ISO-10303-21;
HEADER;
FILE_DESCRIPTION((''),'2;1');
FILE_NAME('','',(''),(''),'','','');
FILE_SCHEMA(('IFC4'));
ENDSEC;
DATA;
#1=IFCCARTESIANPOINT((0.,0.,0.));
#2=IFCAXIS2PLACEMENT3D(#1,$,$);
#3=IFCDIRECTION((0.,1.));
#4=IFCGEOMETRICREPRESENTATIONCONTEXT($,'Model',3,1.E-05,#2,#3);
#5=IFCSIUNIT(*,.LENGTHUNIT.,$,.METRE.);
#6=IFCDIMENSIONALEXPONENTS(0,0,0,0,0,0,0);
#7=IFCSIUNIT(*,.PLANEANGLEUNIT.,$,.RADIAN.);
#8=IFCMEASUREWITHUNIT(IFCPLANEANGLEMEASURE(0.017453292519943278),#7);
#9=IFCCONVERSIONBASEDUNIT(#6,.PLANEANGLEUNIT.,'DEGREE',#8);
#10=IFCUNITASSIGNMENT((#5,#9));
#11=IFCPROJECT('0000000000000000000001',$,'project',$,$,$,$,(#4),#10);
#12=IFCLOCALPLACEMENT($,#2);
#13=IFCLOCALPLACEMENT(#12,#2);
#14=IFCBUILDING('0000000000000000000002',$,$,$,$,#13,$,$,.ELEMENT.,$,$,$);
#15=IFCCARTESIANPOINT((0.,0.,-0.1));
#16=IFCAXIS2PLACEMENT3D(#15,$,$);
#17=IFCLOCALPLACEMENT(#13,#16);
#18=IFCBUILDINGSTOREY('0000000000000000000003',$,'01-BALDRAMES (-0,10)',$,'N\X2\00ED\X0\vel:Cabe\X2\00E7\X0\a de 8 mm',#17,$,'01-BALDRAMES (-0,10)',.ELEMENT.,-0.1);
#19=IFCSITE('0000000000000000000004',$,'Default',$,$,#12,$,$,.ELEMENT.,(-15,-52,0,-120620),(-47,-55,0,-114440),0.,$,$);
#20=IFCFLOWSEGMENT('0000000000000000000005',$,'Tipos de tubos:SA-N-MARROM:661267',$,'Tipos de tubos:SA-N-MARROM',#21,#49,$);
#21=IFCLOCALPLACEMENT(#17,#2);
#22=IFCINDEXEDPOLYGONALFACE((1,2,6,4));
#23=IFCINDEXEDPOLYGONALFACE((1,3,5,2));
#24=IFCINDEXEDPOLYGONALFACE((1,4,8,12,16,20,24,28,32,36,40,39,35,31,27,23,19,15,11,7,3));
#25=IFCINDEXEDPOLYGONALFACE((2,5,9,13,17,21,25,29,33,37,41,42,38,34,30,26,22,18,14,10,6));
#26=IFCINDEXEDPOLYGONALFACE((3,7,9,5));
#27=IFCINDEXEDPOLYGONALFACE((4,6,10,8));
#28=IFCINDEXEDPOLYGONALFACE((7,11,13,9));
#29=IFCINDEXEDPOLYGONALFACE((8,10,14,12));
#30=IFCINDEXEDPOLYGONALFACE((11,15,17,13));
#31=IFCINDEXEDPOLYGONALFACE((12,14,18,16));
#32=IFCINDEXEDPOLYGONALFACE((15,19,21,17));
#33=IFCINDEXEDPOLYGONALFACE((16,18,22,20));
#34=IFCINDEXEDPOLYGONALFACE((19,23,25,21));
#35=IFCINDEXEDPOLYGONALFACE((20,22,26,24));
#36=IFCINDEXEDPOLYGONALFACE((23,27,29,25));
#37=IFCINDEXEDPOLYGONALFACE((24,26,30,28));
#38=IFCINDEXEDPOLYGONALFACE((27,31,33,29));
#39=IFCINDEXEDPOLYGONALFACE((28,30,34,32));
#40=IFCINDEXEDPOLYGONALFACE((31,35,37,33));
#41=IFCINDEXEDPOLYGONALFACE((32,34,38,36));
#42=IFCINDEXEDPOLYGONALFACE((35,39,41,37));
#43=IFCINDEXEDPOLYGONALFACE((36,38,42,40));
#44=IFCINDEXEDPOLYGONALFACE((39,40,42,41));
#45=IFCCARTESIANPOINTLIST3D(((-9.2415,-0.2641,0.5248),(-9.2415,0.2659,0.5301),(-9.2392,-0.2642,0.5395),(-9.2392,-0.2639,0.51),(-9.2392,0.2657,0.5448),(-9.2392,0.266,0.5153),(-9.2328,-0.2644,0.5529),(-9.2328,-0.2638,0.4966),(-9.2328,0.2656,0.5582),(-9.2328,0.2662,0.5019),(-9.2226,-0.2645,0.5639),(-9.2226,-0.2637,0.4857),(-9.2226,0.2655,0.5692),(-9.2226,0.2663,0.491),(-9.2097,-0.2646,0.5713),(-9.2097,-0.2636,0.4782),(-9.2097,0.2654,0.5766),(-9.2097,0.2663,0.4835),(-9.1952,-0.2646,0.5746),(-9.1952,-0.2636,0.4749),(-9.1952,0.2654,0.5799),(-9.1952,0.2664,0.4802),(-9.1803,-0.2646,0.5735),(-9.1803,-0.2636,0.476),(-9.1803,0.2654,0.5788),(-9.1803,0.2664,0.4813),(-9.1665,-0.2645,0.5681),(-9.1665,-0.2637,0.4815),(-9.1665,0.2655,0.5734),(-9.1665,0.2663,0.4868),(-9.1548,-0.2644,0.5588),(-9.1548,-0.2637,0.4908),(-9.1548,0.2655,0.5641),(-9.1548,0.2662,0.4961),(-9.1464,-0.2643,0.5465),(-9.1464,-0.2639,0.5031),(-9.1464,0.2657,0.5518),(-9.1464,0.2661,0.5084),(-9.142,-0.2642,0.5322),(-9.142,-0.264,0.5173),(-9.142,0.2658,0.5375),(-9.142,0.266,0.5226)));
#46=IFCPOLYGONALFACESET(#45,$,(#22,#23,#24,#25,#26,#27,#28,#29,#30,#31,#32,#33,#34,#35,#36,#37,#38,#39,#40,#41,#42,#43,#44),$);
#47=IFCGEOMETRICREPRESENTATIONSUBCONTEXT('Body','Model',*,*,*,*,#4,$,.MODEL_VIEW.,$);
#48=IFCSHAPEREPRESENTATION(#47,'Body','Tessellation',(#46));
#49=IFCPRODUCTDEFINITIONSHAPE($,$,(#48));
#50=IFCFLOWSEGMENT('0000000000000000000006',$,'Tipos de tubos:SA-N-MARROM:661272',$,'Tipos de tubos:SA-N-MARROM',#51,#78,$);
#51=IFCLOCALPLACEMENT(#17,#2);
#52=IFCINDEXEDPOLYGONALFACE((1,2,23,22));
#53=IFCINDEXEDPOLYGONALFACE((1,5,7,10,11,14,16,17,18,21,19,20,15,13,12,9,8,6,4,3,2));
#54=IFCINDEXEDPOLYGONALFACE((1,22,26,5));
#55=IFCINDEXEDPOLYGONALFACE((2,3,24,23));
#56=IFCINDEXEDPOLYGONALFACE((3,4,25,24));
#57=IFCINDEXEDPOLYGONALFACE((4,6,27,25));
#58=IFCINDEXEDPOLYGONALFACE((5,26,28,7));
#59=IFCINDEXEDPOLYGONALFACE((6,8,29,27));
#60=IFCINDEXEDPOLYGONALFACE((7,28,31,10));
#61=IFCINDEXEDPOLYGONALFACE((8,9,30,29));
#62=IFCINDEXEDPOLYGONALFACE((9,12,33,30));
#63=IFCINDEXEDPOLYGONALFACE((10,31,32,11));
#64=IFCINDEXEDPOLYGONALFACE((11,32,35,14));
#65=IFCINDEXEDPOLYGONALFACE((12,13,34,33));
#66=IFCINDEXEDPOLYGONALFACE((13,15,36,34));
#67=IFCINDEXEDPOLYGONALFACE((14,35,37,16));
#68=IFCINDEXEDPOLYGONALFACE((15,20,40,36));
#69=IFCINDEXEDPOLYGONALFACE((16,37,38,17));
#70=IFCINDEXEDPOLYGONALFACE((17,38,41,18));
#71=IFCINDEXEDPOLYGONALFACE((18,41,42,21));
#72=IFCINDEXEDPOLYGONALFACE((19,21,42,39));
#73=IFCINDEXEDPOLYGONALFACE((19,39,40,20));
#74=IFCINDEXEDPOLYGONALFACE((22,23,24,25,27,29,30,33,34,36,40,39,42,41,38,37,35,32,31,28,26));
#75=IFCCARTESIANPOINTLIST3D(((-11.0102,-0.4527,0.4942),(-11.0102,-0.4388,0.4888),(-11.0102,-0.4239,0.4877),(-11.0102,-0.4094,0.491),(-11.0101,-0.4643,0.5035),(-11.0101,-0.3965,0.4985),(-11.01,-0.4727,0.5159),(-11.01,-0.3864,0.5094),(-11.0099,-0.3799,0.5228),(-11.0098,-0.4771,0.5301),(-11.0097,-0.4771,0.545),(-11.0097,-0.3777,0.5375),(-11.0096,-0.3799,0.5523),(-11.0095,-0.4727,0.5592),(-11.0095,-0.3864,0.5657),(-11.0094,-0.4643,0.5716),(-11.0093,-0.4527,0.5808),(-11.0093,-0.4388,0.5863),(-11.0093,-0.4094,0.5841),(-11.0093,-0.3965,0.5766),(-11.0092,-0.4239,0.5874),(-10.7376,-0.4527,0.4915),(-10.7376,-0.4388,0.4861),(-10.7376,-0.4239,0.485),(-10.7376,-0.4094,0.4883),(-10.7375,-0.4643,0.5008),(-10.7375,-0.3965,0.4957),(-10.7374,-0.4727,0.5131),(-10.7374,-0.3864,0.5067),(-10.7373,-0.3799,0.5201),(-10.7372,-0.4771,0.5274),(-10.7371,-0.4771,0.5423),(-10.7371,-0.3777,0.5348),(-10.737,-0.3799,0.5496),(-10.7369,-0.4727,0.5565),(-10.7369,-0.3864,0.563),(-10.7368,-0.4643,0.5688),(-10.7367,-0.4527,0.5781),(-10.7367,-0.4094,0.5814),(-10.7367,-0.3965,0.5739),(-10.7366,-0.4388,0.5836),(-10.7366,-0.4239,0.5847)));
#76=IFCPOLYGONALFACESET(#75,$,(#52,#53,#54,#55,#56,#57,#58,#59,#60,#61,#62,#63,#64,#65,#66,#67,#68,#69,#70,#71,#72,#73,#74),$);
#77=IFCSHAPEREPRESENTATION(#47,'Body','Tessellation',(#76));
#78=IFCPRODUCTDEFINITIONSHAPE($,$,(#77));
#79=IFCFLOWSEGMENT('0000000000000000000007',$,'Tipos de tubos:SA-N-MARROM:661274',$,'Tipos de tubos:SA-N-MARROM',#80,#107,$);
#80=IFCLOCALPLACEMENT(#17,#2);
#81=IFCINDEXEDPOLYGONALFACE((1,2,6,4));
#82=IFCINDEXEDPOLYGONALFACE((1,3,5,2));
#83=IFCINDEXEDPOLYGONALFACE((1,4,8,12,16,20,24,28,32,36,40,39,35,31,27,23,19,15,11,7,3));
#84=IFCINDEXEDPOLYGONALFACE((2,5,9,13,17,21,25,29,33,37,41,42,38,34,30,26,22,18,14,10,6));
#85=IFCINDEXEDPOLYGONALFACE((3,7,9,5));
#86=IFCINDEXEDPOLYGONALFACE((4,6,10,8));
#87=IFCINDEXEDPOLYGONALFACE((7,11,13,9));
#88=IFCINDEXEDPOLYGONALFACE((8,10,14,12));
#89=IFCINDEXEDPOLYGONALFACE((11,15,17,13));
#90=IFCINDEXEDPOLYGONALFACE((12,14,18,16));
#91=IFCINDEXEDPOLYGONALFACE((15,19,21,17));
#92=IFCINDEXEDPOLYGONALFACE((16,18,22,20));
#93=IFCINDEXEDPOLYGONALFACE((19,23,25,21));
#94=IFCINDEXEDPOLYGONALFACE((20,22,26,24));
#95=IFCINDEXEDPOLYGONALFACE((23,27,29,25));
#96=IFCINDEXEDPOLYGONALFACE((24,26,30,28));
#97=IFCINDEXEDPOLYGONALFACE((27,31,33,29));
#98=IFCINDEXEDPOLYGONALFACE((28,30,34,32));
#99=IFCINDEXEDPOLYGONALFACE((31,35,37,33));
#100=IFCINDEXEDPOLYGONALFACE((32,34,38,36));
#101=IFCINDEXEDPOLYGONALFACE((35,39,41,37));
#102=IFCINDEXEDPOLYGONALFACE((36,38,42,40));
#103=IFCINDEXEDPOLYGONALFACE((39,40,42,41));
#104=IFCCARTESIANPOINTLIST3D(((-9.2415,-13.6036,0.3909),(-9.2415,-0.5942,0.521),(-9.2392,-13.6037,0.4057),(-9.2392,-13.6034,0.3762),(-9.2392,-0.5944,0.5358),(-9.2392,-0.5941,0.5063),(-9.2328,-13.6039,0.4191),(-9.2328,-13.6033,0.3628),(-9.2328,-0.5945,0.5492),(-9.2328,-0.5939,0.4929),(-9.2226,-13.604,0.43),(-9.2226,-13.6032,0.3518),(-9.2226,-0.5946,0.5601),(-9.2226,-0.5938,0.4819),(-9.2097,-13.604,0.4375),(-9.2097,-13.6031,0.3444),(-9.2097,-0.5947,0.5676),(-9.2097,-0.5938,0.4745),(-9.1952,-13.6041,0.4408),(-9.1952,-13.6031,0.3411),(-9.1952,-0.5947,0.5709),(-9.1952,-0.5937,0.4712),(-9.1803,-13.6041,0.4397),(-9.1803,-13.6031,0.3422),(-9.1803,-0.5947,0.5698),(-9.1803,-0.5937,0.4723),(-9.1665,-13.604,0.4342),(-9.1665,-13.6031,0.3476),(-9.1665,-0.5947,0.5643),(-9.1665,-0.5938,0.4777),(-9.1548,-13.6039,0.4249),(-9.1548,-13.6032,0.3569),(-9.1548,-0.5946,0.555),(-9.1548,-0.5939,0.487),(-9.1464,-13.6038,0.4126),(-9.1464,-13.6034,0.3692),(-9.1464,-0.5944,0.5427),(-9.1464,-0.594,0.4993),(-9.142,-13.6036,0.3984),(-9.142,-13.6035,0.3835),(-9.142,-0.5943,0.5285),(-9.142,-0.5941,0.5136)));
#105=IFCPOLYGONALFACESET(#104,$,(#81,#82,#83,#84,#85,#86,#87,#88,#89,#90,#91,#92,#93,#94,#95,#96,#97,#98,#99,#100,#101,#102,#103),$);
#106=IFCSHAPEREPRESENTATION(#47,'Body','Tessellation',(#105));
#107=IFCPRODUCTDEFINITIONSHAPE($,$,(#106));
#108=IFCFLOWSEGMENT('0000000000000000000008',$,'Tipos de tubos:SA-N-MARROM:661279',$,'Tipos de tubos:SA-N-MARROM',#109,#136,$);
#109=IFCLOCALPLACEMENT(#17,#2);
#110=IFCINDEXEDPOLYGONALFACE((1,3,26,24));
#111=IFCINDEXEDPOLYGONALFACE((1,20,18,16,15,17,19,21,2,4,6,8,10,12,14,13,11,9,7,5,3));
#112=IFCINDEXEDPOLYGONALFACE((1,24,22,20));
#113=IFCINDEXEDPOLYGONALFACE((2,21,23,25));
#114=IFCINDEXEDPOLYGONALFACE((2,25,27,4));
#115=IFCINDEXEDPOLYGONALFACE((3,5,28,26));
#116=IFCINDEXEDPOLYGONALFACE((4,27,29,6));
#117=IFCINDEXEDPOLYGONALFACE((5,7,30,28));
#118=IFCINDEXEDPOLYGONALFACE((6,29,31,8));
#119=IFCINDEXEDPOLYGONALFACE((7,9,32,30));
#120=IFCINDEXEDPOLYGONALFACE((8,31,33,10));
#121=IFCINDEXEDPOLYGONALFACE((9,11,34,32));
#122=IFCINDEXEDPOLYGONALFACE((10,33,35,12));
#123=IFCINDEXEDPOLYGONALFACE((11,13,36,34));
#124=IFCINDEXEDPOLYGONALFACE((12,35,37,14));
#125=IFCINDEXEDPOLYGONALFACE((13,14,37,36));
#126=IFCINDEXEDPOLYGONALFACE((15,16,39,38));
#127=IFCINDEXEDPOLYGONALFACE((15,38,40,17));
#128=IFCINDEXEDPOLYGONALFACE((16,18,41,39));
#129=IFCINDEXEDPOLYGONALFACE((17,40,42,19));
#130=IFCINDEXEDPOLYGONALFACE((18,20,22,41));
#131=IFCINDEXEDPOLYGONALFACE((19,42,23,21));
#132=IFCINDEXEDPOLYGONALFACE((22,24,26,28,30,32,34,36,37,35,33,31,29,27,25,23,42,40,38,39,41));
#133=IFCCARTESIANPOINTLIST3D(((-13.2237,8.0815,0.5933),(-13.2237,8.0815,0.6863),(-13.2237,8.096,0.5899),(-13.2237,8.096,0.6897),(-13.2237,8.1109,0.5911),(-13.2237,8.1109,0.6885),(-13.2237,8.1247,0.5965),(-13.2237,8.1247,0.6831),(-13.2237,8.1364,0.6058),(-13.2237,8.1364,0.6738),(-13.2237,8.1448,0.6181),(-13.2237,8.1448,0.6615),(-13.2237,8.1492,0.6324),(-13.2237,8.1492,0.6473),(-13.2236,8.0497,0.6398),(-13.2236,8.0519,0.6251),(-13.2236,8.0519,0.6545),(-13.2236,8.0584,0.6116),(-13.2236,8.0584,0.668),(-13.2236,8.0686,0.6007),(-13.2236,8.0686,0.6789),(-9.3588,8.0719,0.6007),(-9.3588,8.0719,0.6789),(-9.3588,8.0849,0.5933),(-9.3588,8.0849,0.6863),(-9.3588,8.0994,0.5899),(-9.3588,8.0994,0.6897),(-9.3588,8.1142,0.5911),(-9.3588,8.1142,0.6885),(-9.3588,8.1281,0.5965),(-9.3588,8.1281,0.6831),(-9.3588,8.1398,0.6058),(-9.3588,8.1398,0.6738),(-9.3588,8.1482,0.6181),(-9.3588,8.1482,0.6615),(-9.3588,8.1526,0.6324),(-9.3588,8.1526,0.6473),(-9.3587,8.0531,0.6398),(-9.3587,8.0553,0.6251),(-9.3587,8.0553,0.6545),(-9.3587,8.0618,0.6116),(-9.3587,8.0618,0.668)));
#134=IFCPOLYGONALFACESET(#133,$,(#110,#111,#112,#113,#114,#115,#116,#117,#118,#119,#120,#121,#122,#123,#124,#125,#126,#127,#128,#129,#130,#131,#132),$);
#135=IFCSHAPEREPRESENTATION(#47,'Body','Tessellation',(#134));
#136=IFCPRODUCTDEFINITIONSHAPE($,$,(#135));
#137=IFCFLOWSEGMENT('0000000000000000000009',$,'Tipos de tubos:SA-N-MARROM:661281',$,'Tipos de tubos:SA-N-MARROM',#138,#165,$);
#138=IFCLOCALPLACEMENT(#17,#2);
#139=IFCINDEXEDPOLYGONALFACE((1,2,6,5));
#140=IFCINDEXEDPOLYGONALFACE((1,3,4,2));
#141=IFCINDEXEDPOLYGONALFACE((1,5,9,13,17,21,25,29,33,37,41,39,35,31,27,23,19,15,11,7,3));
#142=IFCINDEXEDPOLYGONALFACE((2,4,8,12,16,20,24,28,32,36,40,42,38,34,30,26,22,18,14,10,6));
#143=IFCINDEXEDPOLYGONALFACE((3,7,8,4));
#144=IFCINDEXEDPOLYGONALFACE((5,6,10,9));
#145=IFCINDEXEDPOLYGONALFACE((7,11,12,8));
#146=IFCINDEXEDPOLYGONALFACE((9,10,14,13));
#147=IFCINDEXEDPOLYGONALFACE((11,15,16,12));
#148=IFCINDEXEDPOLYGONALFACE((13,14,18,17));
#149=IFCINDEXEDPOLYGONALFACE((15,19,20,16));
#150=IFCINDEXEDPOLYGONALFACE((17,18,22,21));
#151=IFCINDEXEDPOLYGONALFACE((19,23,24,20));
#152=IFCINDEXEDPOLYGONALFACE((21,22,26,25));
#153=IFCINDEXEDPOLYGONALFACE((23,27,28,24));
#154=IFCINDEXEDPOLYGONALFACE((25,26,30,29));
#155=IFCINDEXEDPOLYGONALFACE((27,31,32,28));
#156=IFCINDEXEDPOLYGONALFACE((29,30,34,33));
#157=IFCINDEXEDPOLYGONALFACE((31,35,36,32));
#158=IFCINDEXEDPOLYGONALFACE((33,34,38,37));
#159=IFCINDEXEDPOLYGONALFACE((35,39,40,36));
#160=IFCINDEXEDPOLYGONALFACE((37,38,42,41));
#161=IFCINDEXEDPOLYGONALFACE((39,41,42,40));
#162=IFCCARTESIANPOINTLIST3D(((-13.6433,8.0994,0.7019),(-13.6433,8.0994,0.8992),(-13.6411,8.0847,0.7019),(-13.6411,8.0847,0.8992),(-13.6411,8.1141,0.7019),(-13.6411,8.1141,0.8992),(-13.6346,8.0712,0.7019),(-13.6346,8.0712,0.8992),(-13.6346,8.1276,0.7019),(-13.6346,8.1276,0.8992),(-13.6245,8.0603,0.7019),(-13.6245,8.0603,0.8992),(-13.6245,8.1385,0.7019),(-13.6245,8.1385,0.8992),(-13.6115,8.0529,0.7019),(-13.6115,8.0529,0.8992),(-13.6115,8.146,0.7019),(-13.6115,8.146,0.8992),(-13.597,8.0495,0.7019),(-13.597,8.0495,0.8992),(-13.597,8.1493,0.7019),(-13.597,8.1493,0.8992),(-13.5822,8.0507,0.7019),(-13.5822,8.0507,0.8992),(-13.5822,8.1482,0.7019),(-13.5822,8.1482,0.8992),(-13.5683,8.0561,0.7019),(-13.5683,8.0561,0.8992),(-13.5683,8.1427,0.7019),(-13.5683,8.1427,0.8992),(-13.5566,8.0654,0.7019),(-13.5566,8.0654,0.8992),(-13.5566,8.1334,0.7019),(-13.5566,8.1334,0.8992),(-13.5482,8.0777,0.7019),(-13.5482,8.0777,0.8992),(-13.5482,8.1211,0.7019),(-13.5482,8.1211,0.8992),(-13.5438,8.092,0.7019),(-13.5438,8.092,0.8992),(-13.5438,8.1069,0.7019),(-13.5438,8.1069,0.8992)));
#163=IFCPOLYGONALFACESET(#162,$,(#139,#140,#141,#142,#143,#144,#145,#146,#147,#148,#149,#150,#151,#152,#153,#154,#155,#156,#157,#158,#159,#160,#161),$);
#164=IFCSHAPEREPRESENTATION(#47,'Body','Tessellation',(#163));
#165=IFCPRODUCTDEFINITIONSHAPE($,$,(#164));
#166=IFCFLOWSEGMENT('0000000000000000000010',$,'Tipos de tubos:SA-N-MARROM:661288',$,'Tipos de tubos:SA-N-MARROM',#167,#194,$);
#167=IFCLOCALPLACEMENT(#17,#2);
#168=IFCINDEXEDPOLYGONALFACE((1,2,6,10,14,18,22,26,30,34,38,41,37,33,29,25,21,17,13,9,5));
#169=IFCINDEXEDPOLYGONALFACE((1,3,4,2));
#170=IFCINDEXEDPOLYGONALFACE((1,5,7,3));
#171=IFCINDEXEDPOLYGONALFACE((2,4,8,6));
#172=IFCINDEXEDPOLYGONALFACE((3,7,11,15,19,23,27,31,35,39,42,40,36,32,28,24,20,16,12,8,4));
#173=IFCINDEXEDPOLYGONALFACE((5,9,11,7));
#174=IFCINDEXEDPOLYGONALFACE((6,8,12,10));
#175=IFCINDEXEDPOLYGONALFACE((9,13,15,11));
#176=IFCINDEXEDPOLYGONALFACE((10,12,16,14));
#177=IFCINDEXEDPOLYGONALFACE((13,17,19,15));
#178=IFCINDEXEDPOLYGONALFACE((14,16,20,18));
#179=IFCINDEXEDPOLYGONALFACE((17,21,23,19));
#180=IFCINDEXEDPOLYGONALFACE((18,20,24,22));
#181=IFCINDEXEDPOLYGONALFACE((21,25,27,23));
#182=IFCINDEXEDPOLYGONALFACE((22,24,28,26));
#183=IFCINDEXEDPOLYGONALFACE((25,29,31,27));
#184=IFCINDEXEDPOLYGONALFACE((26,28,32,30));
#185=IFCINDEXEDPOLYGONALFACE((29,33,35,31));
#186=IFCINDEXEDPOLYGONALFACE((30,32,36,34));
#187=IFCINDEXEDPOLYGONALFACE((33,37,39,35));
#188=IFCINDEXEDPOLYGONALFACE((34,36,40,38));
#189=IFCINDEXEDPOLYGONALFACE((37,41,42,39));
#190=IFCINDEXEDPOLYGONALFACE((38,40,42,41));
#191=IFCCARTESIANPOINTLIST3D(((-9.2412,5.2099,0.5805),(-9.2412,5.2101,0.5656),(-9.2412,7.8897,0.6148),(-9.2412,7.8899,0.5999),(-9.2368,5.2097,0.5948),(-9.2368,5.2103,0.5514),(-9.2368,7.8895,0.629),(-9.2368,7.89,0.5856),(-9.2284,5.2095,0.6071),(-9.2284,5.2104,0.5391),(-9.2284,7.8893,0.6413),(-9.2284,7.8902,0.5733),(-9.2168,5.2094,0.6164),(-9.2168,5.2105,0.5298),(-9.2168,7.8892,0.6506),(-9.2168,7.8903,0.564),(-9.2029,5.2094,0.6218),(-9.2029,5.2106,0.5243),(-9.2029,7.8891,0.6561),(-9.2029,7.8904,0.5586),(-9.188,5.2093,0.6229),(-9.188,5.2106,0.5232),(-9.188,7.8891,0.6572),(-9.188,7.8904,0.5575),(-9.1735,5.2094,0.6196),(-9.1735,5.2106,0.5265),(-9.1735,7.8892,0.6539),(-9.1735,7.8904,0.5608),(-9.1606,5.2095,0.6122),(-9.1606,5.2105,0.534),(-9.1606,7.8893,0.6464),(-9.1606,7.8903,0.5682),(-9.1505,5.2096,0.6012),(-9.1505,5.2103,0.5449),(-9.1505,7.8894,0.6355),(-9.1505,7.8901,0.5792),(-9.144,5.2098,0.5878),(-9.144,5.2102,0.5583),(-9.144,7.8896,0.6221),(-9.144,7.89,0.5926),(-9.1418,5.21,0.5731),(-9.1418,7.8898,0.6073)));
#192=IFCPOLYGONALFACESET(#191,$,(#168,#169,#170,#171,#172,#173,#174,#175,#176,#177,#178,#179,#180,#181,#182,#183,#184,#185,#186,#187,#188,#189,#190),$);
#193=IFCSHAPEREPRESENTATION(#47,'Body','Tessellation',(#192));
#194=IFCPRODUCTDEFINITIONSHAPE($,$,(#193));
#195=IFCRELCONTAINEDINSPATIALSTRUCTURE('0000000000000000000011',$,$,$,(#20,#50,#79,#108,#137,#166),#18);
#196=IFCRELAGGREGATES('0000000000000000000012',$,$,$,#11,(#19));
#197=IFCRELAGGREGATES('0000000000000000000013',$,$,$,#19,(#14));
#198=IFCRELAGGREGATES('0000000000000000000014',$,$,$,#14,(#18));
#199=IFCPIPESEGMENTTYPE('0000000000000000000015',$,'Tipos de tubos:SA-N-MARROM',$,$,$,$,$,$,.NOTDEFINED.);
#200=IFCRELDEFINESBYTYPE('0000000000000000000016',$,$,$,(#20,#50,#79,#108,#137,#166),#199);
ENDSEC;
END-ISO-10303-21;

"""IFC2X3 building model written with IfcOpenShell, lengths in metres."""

from ifc_helpers import new_model, entity, si_unit, converted_unit, direction, frame, frame_2d, origin, origin_2d_with_axis, place, context, subcontext, project, spatial, circle, extrude, type_object, element, save


model = new_model("IFC2X3")

# Units and contexts
model_context = context("Model", 3, precision=1e-05, world=origin(), true_north=direction((0.0, 1.0)))
body_context = subcontext(model_context, "Body", "Model", "MODEL_VIEW")
ifc_project = project(units=[si_unit("LENGTHUNIT", "METRE"), converted_unit("PLANEANGLEUNIT", "DEGREE", entity("IfcPlaneAngleMeasure", 0.017453292519943278), si_unit("PLANEANGLEUNIT", "RADIAN"), dimensions=[0, 0, 0, 0, 0, 0, 0])], contexts=[model_context])

# Site, building, storey
site_placement = place(None, origin())
site = spatial("IfcSite", under=ifc_project, at=site_placement, Name="Default", CompositionType="ELEMENT", RefLatitude=(-15, -52, 0, -120620), RefLongitude=(-47, -55, 0, -114440), RefElevation=0.0)
building_placement = place(site_placement, origin())
building = spatial("IfcBuilding", under=site, at=building_placement, CompositionType="ELEMENT")
storey_placement = place(building_placement, frame((0.0, 0.0, -0.1)))
storey = spatial("IfcBuildingStorey", under=building, at=storey_placement, Name="01-BALDRAMES (-0,10)", ObjectType="Nível:Cabeça de 8 mm", LongName="01-BALDRAMES (-0,10)", CompositionType="ELEMENT", Elevation=-0.1)

# Flow segments
pipe_segment_type_1 = type_object("IfcPipeSegmentType", Name="Tipos de tubos:SA-N-MARROM", PredefinedType="NOTDEFINED")
flow_segment_1_placement = place(storey_placement, origin())
element("IfcFlowSegment", 1, at=flow_segment_1_placement, inside=storey, type_object=pipe_segment_type_1, Name="Tipos de tubos:SA-N-MARROM:661267", ObjectType="Tipos de tubos:SA-N-MARROM", context=body_context, shape_type="SweptSolid", body=[
    extrude(circle(Radius=0.05, at=frame_2d((0.0, 0.0), x_axis=(1.0, 0.0))), frame((-9.1915, -0.2641, 0.5248), z_axis=(-0.000001, 0.99995, 0.009999), x_axis=(-1.0, -0.000001, 0.0)), (0.0, 0.0, 1.0), 0.53),
])
flow_segment_2_placement = place(storey_placement, origin())
element("IfcFlowSegment", 2, at=flow_segment_2_placement, inside=storey, type_object=pipe_segment_type_1, Name="Tipos de tubos:SA-N-MARROM:661272", ObjectType="Tipos de tubos:SA-N-MARROM", context=body_context, shape_type="SweptSolid", body=[
    extrude(circle(Radius=0.05, at=frame_2d((0.0, 0.0), x_axis=(1.0, 0.0))), frame((-11.0097, -0.4277, 0.5375), z_axis=(0.99995, 0.000001, -0.01), x_axis=(-0.000001, 1.0, 0.0)), (0.0, 0.0, 1.0), 0.2726),
])
flow_segment_3_placement = place(storey_placement, origin())
element("IfcFlowSegment", 3, at=flow_segment_3_placement, inside=storey, type_object=pipe_segment_type_1, Name="Tipos de tubos:SA-N-MARROM:661274", ObjectType="Tipos de tubos:SA-N-MARROM", context=body_context, shape_type="SweptSolid", body=[
    extrude(circle(Radius=0.05, at=frame_2d((0.0, 0.0), x_axis=(1.0, 0.0))), frame((-9.1915, -13.6036, 0.3909), z_axis=(-0.000001, 0.99995, 0.01), x_axis=(-1.0, -0.000001, 0.0)), (0.0, 0.0, 1.0), 13.01),
])
flow_segment_4_placement = place(storey_placement, origin())
element("IfcFlowSegment", 4, at=flow_segment_4_placement, inside=storey, type_object=pipe_segment_type_1, Name="Tipos de tubos:SA-N-MARROM:661279", ObjectType="Tipos de tubos:SA-N-MARROM", context=body_context, shape_type="SweptSolid", body=[
    extrude(circle(Radius=0.05, at=origin_2d_with_axis()), frame((-13.2237, 8.0997, 0.6398), z_axis=(1.0, 0.000878, 0.0), x_axis=(0.000878, -1.0, 0.0)), (0.0, 0.0, 1.0), 3.8649),
])
flow_segment_5_placement = place(storey_placement, origin())
element("IfcFlowSegment", 5, at=flow_segment_5_placement, inside=storey, type_object=pipe_segment_type_1, Name="Tipos de tubos:SA-N-MARROM:661281", ObjectType="Tipos de tubos:SA-N-MARROM", context=body_context, shape_type="SweptSolid", body=[
    extrude(circle(Radius=0.05, at=frame_2d((0.0, 0.0), x_axis=(1.0, 0.0))), frame((-13.5933, 8.0994, 0.7019), z_axis=(0.0, 0.0, 1.0), x_axis=(-1.0, 0.0, 0.0)), (0.0, 0.0, 1.0), 0.1973),
])
flow_segment_6_placement = place(storey_placement, origin())
element("IfcFlowSegment", 6, at=flow_segment_6_placement, inside=storey, type_object=pipe_segment_type_1, Name="Tipos de tubos:SA-N-MARROM:661288", ObjectType="Tipos de tubos:SA-N-MARROM", context=body_context, shape_type="SweptSolid", body=[
    extrude(circle(Radius=0.05, at=frame_2d((0.0, 0.0), x_axis=(1.0, 0.0))), frame((-9.1918, 5.21, 0.5731), z_axis=(-0.000001, 0.999918, 0.01278), x_axis=(1.0, 0.000001, 0.0)), (0.0, 0.0, 1.0), 2.68),
])

save(model, "model.ifc")
